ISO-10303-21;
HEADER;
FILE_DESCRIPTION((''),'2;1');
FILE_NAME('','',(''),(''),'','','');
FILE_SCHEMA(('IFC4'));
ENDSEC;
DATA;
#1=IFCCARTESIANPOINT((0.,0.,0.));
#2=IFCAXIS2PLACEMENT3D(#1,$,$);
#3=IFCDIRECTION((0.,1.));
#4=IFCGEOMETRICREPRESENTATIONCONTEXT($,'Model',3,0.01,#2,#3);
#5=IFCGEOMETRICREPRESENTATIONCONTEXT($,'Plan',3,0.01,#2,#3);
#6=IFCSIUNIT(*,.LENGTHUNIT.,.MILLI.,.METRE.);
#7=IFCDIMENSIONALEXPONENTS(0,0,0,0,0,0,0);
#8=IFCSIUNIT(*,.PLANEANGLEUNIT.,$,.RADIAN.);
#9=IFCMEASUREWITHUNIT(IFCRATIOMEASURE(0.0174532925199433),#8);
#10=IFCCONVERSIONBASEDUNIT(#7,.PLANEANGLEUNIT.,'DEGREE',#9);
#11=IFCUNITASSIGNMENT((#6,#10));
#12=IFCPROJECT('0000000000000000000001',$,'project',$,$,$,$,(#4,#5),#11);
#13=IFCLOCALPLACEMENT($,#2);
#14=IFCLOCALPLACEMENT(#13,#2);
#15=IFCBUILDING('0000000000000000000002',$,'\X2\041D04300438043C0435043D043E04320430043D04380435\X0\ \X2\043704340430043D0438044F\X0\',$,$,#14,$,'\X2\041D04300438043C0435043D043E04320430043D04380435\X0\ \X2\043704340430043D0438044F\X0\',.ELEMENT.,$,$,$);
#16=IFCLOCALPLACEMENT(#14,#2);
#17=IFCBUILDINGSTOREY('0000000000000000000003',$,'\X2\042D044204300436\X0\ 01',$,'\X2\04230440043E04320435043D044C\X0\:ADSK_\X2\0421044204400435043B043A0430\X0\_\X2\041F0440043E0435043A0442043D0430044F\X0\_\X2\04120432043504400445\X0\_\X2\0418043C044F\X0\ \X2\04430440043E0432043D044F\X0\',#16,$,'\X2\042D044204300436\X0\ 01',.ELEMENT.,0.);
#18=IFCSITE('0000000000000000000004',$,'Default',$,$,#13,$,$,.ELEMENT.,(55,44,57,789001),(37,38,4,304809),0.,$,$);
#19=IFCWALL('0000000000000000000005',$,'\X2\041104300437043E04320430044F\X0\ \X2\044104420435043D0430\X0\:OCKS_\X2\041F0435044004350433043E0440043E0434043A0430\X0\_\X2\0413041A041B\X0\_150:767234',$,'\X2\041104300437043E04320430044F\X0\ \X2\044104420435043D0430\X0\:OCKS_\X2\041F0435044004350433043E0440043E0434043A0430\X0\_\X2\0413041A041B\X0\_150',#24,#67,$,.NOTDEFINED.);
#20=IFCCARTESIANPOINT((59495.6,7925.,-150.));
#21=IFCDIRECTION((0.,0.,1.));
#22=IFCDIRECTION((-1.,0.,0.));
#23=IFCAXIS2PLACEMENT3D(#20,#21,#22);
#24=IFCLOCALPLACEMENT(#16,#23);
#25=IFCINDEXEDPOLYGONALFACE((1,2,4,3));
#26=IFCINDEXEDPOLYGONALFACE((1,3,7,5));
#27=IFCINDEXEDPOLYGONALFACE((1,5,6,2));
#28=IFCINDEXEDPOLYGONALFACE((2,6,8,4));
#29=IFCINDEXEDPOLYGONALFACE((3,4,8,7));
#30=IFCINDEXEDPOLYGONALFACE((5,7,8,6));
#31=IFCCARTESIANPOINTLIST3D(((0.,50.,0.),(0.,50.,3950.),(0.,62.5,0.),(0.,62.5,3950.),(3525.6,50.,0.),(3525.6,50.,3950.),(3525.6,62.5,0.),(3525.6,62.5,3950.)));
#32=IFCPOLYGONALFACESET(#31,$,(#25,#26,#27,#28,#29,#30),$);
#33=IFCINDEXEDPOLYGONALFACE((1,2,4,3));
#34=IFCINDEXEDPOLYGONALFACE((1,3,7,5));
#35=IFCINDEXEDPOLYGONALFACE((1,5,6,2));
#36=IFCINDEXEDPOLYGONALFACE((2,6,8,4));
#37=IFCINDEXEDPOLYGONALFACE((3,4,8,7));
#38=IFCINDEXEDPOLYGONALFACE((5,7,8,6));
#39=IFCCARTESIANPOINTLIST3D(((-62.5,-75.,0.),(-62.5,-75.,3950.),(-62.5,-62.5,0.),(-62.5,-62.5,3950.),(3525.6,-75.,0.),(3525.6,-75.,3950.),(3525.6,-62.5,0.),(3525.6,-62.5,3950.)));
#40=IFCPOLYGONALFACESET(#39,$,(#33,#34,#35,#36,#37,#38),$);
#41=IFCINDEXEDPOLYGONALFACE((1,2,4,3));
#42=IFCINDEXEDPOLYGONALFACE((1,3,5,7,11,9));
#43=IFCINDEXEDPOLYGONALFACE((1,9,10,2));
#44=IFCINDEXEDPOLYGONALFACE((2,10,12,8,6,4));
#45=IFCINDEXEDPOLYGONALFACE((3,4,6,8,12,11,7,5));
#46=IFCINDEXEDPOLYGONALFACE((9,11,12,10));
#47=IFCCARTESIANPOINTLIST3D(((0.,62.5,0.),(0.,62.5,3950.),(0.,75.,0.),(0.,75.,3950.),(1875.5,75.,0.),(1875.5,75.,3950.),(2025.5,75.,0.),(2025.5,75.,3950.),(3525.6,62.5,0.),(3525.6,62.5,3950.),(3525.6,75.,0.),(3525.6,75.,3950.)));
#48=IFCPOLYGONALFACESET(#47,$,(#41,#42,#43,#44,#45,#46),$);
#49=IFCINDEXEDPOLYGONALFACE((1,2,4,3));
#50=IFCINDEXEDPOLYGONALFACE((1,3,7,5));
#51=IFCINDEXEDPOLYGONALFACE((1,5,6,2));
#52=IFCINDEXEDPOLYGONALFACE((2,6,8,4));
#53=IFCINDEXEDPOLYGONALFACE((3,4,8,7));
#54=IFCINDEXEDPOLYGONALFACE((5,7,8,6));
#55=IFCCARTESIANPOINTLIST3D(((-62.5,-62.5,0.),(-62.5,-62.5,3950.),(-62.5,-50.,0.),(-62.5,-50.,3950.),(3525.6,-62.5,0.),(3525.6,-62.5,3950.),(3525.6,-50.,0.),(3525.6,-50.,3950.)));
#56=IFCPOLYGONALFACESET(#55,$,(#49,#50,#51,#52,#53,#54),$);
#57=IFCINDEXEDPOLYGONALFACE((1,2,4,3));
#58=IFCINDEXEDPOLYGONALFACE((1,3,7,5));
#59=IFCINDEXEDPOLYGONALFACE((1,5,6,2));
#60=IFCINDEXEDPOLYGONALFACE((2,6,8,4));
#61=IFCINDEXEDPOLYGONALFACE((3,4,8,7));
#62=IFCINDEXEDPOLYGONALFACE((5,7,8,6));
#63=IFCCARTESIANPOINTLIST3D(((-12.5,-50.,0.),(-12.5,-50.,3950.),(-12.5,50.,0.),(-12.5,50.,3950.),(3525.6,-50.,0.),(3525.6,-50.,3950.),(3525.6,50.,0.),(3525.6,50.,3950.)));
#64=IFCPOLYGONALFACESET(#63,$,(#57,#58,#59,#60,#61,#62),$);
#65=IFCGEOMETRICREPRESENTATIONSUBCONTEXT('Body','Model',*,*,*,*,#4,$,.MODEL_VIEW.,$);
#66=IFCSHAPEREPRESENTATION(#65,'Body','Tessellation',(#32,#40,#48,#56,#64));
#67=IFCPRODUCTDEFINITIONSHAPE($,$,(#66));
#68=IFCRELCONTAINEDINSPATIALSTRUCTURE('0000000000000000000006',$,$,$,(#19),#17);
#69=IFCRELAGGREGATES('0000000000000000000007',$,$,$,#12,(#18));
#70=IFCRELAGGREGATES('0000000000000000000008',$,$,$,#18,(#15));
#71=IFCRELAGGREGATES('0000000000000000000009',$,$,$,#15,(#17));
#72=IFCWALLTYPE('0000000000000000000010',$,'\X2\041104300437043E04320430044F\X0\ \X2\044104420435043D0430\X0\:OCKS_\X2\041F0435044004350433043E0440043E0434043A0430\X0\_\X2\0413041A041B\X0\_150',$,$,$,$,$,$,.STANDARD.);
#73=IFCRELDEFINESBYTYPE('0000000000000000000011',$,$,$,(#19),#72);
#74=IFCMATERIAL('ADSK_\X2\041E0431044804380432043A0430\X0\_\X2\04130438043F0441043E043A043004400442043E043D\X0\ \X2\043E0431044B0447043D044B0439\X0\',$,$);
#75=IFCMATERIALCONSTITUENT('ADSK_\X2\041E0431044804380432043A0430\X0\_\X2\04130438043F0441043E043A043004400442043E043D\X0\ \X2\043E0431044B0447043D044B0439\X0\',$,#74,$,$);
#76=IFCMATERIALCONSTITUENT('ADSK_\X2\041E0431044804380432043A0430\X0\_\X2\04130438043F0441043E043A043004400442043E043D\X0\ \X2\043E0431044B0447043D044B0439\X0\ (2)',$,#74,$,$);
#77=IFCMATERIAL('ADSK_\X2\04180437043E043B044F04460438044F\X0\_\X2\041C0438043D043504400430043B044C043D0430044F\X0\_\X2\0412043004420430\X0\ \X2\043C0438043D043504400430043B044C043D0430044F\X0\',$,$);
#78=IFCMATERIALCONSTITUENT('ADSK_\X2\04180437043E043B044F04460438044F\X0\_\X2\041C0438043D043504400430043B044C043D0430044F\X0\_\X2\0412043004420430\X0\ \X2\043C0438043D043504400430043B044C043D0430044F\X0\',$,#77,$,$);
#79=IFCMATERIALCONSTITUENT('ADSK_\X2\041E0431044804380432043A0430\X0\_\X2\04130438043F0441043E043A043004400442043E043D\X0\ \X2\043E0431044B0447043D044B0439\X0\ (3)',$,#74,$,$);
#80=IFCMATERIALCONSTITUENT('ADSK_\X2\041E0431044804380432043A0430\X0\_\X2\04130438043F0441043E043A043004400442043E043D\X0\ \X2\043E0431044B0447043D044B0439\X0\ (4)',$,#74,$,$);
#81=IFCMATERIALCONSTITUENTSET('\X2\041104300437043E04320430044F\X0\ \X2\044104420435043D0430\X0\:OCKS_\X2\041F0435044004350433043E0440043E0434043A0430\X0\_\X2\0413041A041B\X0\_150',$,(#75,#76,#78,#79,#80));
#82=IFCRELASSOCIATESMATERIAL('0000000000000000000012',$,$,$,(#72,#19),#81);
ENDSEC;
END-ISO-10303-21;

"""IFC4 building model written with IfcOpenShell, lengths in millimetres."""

from ifc_helpers import new_model, entity, si_unit, converted_unit, direction, frame, origin, place, context, subcontext, project, spatial, indexed_curve, outline, extrude, material, constituent, constituent_set, type_object, element, save


model = new_model("IFC4")

# Units and contexts
model_context = context("Model", 3, precision=0.01, world=origin(), true_north=direction((0.0, 1.0)))
plan_context = context("Plan", 3, precision=0.01, world=origin(), true_north=direction((0.0, 1.0)))
body_context = subcontext(model_context, "Body", "Model", "MODEL_VIEW")
ifc_project = project(units=[si_unit("LENGTHUNIT", "METRE", prefix="MILLI"), converted_unit("PLANEANGLEUNIT", "DEGREE", entity("IfcRatioMeasure", 0.0174532925199433), si_unit("PLANEANGLEUNIT", "RADIAN"), dimensions=[0, 0, 0, 0, 0, 0, 0])], contexts=[model_context, plan_context])

# Site, building, storey
site_placement = place(None, frame((0.0, 0.0, 0.0)))
site = spatial("IfcSite", under=ifc_project, at=site_placement, Name="Default", CompositionType="ELEMENT", RefLatitude=(55, 44, 57, 789001), RefLongitude=(37, 38, 4, 304809), RefElevation=0.0)
building_placement = place(site_placement, origin())
building = spatial("IfcBuilding", under=site, at=building_placement, Name="Наименование здания", LongName="Наименование здания", CompositionType="ELEMENT")
storey_placement = place(building_placement, origin())
storey = spatial("IfcBuildingStorey", under=building, at=storey_placement, Name="Этаж 01", ObjectType="Уровень:ADSK_Стрелка_Проектная_Вверх_Имя уровня", LongName="Этаж 01", CompositionType="ELEMENT", Elevation=0.0)

# Wall
ifc_material_1 = material(Name="ADSK_Обшивка_Гипсокартон обычный")
ifc_constituent_1 = constituent(ifc_material_1, Name="ADSK_Обшивка_Гипсокартон обычный")
ifc_constituent_2 = constituent(ifc_material_1, Name="ADSK_Обшивка_Гипсокартон обычный (2)")
ifc_material_2 = material(Name="ADSK_Изоляция_Минеральная_Вата минеральная")
ifc_constituent_3 = constituent(ifc_material_2, Name="ADSK_Изоляция_Минеральная_Вата минеральная")
ifc_constituent_4 = constituent(ifc_material_1, Name="ADSK_Обшивка_Гипсокартон обычный (3)")
ifc_constituent_5 = constituent(ifc_material_1, Name="ADSK_Обшивка_Гипсокартон обычный (4)")
ifc_constituent_set_1 = constituent_set(constituents=[ifc_constituent_1, ifc_constituent_2, ifc_constituent_3, ifc_constituent_4, ifc_constituent_5], Name="Базовая стена:OCKS_Перегородка_ГКЛ_150")
wall_type_1 = type_object("IfcWallType", Name="Базовая стена:OCKS_Перегородка_ГКЛ_150", PredefinedType="STANDARD", material=ifc_constituent_set_1)
wall_1_placement = place(storey_placement, frame((59495.6, 7925.0, -150.0), z_axis=(0.0, 0.0, 1.0), x_axis=(-1.0, 0.0, 0.0)))
element("IfcWall", 1, at=wall_1_placement, inside=storey, type_object=wall_type_1, material=ifc_constituent_set_1, Name="Базовая стена:OCKS_Перегородка_ГКЛ_150:767234", ObjectType="Базовая стена:OCKS_Перегородка_ГКЛ_150", PredefinedType="NOTDEFINED", context=body_context, shape_type="SweptSolid", body=[
    extrude(outline(indexed_curve([(-1762.8, -6.3), (1762.8, -6.3), (1762.8, 6.3), (-1762.8, 6.3), (-1762.8, -6.3)], self_intersect=False)), frame((1762.8, 56.2, 0.0)), (0.0, 0.0, 1.0), 3950.0),
    extrude(outline(indexed_curve([(-6.3, -1794.1), (6.2, -1794.1), (6.3, 1794.1), (-6.2, 1794.1), (-6.3, -1794.1)], self_intersect=False)), frame((1731.6, -68.8, 0.0), z_axis=(0.0, 0.0, 1.0), x_axis=(0.0, 1.0, 0.0)), (0.0, 0.0, 1.0), 3950.0),
    extrude(outline(indexed_curve([(-200.1, -4.2), (-50.1, -4.2), (1825.4, -4.2), (1825.4, 8.3), (-1700.2, 8.3), (-1700.2, -4.2), (-200.1, -4.2)], self_intersect=False)), frame((1825.4, 70.8, 0.0), z_axis=(0.0, 0.0, 1.0), x_axis=(-1.0, 0.0, 0.0)), (0.0, 0.0, 1.0), 3950.0),
    extrude(outline(indexed_curve([(-1794.1, -6.3), (1794.1, -6.3), (1794.1, 6.3), (-1794.1, 6.3), (-1794.1, -6.3)], self_intersect=False)), frame((1731.6, -56.3, 0.0)), (0.0, 0.0, 1.0), 3950.0),
    extrude(outline(indexed_curve([(-1769.1, -50.0), (1769.1, -50.0), (1769.1, 50.0), (-1769.1, 50.0), (-1769.1, -50.0)], self_intersect=False)), frame((1756.6, 0.0, 0.0)), (0.0, 0.0, 1.0), 3950.0),
])

save(model, "model.ifc")
